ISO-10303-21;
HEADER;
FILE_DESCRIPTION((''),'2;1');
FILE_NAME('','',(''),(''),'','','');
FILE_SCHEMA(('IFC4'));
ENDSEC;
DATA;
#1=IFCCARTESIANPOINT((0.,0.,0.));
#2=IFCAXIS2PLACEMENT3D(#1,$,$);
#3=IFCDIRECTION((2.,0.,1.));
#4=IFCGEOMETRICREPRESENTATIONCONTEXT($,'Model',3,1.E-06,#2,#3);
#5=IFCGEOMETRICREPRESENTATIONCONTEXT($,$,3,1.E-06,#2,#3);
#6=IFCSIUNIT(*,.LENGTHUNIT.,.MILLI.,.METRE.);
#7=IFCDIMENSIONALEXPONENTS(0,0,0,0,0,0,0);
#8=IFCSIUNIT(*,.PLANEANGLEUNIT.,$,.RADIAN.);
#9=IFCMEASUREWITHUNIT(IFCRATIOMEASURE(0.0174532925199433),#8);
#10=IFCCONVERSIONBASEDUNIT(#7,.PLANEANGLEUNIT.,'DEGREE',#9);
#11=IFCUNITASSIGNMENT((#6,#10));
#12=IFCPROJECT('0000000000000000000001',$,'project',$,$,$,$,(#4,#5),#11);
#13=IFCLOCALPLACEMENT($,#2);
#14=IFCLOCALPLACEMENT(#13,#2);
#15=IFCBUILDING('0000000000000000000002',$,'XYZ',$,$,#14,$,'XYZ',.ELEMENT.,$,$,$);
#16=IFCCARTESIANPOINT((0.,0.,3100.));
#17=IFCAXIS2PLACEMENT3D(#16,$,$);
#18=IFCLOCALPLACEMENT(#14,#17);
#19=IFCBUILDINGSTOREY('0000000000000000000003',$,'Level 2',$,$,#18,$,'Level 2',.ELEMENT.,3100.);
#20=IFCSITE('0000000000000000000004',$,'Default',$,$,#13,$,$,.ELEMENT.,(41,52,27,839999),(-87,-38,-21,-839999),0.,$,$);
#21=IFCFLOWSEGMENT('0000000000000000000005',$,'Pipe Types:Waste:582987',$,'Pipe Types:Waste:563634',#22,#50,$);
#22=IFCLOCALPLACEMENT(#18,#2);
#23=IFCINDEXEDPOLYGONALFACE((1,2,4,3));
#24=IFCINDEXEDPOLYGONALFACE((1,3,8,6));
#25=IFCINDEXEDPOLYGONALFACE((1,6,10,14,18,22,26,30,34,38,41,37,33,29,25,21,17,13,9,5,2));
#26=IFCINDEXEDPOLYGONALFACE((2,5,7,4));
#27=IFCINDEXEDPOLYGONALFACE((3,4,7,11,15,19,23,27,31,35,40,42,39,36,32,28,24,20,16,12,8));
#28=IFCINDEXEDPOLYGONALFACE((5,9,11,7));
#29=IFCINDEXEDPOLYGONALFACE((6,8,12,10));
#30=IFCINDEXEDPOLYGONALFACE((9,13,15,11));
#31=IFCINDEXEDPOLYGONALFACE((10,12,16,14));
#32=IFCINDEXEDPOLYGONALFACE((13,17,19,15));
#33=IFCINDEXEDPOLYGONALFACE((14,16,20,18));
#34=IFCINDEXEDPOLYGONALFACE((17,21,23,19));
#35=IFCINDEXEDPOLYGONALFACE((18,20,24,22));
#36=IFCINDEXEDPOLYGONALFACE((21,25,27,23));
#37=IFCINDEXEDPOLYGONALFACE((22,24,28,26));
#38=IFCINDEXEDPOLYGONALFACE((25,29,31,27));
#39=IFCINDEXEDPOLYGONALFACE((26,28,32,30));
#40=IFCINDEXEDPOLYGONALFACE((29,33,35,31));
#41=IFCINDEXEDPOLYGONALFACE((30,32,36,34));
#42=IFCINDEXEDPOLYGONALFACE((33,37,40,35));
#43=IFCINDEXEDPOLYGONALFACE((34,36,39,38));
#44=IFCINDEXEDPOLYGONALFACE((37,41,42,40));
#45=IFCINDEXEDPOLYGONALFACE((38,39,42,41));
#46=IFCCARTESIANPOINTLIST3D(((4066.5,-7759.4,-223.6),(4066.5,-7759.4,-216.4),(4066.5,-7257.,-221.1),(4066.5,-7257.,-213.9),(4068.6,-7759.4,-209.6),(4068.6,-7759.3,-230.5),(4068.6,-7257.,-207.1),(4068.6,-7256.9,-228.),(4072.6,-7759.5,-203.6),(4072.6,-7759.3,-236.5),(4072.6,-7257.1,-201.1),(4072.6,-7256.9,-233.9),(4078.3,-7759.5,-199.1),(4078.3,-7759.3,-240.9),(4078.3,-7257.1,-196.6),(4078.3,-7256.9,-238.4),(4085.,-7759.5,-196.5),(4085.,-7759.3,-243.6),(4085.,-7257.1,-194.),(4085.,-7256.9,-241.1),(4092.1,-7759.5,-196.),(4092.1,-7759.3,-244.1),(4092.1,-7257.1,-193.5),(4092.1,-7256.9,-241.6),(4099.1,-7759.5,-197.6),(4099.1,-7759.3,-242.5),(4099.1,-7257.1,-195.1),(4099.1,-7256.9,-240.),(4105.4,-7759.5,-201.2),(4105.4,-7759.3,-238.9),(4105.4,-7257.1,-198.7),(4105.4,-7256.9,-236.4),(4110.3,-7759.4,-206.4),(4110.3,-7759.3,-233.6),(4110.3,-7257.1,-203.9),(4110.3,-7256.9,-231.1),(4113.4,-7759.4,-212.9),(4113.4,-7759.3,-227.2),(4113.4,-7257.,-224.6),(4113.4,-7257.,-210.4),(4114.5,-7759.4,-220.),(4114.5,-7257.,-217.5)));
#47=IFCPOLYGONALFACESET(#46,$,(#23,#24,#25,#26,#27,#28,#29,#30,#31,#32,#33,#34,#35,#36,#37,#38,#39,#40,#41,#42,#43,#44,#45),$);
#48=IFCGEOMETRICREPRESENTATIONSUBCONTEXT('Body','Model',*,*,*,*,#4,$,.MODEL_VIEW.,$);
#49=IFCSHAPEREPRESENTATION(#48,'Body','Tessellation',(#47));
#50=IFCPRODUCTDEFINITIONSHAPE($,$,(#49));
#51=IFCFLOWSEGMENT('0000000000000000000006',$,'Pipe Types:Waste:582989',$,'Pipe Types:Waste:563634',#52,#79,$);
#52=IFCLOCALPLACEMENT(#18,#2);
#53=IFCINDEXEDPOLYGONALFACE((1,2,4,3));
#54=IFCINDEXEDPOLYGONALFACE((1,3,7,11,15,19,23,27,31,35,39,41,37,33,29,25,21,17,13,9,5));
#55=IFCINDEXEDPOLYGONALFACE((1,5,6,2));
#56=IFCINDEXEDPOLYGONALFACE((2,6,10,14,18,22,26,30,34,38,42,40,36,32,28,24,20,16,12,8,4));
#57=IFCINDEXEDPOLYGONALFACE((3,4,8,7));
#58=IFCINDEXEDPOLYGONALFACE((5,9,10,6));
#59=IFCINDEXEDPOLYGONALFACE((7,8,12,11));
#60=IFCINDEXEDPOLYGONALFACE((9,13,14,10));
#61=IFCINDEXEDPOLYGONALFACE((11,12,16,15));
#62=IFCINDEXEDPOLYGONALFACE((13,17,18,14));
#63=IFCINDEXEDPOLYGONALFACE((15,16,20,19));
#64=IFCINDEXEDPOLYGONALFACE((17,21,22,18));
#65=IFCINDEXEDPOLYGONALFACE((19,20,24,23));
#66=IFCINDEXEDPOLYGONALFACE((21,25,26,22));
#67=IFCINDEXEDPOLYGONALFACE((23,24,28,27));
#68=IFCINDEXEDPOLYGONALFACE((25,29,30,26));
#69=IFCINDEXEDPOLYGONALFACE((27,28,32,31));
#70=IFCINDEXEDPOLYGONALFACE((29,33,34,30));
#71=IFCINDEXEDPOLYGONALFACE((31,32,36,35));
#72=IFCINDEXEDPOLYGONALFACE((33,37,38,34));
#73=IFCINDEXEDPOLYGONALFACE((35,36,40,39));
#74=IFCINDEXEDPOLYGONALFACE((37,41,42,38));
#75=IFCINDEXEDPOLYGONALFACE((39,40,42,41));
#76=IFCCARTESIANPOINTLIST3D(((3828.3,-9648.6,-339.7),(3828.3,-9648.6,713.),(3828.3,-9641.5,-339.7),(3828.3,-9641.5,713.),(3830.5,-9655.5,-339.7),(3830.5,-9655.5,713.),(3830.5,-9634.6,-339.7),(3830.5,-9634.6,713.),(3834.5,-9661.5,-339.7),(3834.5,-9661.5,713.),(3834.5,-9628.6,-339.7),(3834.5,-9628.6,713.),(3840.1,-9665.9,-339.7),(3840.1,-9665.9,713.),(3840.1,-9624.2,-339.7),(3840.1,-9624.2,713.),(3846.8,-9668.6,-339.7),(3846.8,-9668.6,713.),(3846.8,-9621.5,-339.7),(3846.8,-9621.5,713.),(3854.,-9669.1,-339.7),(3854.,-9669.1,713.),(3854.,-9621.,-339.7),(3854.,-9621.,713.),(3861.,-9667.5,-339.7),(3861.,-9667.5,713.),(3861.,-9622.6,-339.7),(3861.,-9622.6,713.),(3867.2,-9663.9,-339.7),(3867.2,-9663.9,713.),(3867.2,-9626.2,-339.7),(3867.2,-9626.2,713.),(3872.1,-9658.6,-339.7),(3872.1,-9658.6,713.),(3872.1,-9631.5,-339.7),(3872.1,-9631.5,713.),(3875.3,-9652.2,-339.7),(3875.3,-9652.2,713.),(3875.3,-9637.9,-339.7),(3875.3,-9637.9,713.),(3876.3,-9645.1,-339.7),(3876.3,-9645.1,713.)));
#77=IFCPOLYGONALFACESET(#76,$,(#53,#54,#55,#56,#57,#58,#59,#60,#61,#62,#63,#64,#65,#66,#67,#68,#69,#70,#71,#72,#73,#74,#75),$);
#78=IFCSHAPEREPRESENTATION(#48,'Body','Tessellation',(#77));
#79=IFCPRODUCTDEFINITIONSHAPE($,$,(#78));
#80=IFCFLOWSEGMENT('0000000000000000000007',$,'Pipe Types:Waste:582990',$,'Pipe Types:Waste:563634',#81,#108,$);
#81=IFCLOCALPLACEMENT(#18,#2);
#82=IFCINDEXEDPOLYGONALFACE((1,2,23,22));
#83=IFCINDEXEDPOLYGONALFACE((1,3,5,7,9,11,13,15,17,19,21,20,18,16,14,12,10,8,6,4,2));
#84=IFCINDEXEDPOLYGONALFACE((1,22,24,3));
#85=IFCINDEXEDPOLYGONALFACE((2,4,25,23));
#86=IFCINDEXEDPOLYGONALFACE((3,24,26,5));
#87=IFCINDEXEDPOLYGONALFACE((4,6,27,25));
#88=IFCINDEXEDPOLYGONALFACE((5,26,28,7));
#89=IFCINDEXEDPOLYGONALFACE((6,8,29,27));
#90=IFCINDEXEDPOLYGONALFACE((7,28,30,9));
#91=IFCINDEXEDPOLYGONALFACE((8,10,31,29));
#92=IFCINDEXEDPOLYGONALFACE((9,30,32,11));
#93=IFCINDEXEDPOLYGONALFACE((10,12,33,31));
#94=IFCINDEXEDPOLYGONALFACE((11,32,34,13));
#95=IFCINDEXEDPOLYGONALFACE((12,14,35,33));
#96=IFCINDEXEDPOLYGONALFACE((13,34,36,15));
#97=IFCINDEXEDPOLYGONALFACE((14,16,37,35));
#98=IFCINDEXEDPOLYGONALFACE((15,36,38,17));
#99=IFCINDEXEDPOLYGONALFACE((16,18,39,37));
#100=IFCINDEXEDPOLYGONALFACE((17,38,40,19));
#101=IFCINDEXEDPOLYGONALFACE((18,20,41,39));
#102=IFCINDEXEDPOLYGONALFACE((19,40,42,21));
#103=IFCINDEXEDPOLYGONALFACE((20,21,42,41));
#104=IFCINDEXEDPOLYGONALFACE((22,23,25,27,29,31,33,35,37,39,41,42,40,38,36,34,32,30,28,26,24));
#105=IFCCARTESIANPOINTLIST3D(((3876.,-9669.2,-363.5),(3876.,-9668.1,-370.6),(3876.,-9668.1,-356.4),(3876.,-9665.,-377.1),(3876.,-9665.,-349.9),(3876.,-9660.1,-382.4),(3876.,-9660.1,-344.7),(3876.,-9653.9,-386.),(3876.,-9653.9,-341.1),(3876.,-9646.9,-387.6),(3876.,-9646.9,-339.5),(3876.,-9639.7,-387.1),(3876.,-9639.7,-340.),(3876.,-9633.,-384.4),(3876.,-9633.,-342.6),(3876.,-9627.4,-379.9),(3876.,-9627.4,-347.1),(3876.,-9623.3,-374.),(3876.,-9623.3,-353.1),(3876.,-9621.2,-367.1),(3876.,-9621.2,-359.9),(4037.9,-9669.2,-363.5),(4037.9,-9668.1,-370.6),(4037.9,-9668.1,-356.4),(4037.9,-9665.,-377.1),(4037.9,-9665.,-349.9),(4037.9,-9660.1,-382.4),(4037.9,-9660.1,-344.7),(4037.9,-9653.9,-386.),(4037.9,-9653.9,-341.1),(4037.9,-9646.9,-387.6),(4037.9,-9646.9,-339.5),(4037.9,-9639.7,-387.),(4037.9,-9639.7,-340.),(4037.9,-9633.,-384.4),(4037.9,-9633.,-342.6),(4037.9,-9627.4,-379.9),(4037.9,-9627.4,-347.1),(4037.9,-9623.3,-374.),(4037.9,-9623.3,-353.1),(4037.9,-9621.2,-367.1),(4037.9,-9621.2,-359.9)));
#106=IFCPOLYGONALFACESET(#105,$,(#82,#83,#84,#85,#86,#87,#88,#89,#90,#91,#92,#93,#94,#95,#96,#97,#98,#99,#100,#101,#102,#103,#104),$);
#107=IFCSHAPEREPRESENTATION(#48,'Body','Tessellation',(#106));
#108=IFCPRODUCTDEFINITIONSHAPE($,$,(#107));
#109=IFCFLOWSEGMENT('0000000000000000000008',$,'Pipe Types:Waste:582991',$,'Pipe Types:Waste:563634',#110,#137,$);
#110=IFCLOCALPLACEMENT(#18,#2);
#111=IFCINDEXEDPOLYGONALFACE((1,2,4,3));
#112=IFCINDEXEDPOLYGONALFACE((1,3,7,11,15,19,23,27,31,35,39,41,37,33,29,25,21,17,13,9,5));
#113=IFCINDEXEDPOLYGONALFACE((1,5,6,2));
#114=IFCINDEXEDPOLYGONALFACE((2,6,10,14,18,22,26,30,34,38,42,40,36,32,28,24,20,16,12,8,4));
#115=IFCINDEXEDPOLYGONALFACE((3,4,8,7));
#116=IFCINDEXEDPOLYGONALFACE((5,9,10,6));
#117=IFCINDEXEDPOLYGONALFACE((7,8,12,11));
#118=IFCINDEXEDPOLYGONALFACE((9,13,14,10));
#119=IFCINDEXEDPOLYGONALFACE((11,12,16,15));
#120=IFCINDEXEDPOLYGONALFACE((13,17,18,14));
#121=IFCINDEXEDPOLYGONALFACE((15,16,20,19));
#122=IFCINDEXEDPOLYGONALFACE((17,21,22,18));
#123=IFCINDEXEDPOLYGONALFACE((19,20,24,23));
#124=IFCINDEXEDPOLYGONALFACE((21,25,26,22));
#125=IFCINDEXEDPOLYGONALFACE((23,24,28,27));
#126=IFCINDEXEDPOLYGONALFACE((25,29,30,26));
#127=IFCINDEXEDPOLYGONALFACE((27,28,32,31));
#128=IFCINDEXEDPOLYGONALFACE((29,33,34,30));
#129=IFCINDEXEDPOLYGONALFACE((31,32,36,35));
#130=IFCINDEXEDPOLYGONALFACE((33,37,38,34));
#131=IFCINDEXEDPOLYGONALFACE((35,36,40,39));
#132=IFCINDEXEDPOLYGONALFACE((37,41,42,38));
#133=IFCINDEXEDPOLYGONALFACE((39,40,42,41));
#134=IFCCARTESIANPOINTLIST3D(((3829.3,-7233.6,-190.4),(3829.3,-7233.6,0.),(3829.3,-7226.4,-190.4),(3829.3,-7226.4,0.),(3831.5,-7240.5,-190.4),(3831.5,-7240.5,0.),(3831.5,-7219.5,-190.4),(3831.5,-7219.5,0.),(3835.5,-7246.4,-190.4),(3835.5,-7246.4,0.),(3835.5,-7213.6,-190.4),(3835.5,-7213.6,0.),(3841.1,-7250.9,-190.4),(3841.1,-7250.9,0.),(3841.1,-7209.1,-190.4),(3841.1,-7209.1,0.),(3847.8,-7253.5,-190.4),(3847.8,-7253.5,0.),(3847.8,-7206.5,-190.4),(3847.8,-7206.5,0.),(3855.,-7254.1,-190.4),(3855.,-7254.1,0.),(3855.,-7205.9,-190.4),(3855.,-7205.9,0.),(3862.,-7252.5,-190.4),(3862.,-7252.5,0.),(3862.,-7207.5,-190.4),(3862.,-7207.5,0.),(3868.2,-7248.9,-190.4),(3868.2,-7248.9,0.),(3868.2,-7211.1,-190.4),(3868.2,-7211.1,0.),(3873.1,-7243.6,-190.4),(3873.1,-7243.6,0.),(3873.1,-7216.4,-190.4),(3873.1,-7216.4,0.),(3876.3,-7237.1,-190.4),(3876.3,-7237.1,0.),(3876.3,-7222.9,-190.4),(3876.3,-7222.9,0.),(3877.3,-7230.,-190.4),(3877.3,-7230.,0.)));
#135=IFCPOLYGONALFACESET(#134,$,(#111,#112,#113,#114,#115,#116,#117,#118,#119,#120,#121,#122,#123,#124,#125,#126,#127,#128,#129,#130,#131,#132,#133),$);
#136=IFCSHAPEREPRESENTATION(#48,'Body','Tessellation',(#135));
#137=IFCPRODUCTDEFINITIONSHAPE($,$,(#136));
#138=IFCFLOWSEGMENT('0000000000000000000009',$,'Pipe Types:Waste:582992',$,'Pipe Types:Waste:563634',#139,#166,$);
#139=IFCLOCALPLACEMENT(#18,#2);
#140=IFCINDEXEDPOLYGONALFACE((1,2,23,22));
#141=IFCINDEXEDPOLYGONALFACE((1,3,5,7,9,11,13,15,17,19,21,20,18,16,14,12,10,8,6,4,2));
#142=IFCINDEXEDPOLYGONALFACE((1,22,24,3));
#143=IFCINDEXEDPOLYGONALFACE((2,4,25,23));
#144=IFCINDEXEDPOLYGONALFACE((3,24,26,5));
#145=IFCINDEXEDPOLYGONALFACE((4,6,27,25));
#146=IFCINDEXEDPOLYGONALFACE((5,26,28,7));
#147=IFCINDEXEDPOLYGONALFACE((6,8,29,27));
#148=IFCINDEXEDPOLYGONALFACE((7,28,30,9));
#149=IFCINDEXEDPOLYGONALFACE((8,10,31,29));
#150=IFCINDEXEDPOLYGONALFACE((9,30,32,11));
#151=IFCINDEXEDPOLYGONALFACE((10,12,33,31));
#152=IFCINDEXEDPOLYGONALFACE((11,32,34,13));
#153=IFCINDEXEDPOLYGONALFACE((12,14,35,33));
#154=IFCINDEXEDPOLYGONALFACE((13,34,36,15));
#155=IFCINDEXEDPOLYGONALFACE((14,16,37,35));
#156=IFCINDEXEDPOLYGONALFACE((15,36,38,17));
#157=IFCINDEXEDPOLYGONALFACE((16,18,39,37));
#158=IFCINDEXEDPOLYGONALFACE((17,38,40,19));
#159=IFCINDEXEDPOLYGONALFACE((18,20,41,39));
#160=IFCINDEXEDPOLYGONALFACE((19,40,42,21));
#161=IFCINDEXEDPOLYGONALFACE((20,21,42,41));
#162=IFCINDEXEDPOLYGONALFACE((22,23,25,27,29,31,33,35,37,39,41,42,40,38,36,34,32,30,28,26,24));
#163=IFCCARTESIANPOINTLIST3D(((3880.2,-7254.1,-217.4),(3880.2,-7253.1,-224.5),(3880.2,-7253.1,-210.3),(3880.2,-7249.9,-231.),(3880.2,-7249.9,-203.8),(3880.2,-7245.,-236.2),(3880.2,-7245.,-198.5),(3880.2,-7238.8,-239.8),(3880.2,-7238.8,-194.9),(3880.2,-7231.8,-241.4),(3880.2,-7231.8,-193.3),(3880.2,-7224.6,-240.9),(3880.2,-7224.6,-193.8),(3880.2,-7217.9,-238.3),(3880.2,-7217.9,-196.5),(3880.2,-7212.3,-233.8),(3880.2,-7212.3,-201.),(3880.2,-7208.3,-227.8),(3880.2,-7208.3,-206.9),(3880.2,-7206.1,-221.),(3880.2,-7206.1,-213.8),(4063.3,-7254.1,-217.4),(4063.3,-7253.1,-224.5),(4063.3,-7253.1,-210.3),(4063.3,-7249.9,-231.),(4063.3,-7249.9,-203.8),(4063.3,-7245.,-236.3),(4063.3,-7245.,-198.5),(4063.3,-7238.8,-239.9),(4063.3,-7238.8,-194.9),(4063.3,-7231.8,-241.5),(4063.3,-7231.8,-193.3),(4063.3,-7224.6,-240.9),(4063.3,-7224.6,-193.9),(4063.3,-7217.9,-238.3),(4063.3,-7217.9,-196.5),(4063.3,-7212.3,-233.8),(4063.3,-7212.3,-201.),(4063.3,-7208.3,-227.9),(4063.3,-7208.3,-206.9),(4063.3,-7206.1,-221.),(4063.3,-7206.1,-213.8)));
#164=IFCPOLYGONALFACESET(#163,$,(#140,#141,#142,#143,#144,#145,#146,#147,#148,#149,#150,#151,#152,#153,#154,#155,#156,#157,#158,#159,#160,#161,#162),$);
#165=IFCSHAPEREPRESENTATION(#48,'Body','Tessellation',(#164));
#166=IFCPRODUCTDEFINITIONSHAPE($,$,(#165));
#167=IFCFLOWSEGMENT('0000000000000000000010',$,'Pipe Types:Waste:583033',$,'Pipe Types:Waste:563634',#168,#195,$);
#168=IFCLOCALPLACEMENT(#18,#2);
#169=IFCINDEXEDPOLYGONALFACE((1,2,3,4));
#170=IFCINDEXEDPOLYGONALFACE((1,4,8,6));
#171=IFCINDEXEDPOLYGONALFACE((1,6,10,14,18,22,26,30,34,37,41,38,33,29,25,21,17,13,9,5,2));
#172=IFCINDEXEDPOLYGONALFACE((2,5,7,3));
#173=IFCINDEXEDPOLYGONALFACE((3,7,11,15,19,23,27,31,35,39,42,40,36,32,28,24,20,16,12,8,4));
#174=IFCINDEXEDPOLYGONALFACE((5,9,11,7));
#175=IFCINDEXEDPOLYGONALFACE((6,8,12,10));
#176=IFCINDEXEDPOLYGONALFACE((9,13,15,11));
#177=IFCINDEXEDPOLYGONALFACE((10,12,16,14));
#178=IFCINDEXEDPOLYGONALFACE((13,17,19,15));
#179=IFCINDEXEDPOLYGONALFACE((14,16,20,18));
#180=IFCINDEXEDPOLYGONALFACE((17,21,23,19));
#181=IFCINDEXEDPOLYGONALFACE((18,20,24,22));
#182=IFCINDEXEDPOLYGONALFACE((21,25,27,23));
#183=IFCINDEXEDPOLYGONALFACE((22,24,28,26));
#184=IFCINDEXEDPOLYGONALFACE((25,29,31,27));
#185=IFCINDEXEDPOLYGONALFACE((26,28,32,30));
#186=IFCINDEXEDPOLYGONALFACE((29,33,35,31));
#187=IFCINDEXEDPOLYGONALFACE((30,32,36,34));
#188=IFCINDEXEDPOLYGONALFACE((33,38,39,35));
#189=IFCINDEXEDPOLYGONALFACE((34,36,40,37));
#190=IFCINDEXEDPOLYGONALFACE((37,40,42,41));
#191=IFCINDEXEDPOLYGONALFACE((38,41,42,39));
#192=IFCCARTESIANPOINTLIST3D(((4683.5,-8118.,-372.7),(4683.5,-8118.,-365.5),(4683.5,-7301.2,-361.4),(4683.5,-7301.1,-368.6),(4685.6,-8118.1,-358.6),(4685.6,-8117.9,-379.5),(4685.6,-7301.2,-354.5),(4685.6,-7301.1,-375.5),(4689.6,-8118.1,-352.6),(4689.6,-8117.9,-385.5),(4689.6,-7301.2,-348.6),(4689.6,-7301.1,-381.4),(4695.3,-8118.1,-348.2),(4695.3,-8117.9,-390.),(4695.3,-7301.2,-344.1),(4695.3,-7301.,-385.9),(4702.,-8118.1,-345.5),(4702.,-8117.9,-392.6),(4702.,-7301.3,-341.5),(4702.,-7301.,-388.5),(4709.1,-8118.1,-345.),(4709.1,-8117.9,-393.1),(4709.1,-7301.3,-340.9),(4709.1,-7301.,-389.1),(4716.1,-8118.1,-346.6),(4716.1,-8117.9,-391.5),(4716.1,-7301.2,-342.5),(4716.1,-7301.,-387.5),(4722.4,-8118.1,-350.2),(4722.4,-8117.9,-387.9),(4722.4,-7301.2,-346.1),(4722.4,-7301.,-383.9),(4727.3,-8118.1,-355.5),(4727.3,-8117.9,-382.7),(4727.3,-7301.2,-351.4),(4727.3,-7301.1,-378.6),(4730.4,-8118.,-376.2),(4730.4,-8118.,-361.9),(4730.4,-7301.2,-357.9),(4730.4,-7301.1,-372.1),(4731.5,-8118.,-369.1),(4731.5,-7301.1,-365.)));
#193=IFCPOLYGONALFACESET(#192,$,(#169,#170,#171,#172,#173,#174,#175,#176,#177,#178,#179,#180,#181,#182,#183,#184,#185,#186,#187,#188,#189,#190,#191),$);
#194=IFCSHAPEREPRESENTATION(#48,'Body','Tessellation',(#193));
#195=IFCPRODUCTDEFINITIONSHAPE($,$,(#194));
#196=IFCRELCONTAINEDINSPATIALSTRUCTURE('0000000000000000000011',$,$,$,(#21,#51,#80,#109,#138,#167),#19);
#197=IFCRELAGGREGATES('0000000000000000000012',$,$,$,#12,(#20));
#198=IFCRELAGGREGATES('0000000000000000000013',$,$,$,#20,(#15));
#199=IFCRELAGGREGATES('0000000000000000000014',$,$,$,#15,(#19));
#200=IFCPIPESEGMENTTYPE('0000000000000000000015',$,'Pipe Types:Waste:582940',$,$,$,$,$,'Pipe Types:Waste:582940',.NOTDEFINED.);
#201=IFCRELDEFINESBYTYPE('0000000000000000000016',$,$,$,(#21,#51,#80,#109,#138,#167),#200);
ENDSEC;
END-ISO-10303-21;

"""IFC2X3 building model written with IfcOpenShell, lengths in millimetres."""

from ifc_helpers import new_model, entity, si_unit, converted_unit, direction, frame, frame_2d, origin, origin_2d_with_axis, place, context, subcontext, project, spatial, circle, extrude, type_object, element, save


model = new_model("IFC2X3")

# Units and contexts
model_context = context("Model", 3, precision=1e-06, world=origin(), true_north=direction((2.0, 0.0, 1.0)))
context_of_model = context(None, 3, precision=1e-06, world=origin(), true_north=direction((2.0, 0.0, 1.0)))
body_context = subcontext(model_context, "Body", "Model", "MODEL_VIEW")
ifc_project = project(units=[si_unit("LENGTHUNIT", "METRE", prefix="MILLI"), converted_unit("PLANEANGLEUNIT", "DEGREE", entity("IfcRatioMeasure", 0.0174532925199433), si_unit("PLANEANGLEUNIT", "RADIAN"), dimensions=[0, 0, 0, 0, 0, 0, 0])], contexts=[model_context, context_of_model])

# Site, building, storey
site_placement = place(None, origin())
site = spatial("IfcSite", under=ifc_project, at=site_placement, Name="Default", CompositionType="ELEMENT", RefLatitude=(41, 52, 27, 839999), RefLongitude=(-87, -38, -21, -839999), RefElevation=0.0)
building_placement = place(site_placement, origin())
building = spatial("IfcBuilding", under=site, at=building_placement, Name="XYZ", LongName="XYZ", CompositionType="ELEMENT")
storey_placement = place(building_placement, frame((0.0, 0.0, 3100.0)))
storey = spatial("IfcBuildingStorey", under=building, at=storey_placement, Name="Level 2", LongName="Level 2", CompositionType="ELEMENT", Elevation=3100.0)

# Flow segments
pipe_segment_type_1 = type_object("IfcPipeSegmentType", Name="Pipe Types:Waste:582940", ElementType="Pipe Types:Waste:582940", PredefinedType="NOTDEFINED")
flow_segment_1_placement = place(storey_placement, origin())
element("IfcFlowSegment", 1, at=flow_segment_1_placement, inside=storey, type_object=pipe_segment_type_1, Name="Pipe Types:Waste:582987", ObjectType="Pipe Types:Waste:563634", context=body_context, shape_type="SweptSolid", body=[
    extrude(circle(Radius=24.1, at=frame_2d((0.0, 0.0), x_axis=(1.0, 0.0))), frame((4090.3, -7759.4, -220.0), z_axis=(0.0, 0.999988, 0.005), x_axis=(1.0, 0.0, 0.0)), (0.0, 0.0, 1.0), 502.4),
])
flow_segment_2_placement = place(storey_placement, origin())
element("IfcFlowSegment", 2, at=flow_segment_2_placement, inside=storey, type_object=pipe_segment_type_1, Name="Pipe Types:Waste:582989", ObjectType="Pipe Types:Waste:563634", context=body_context, shape_type="SweptSolid", body=[
    extrude(circle(Radius=24.1, at=origin_2d_with_axis()), frame((3852.2, -9645.1, -339.7)), (0.0, 0.0, 1.0), 1052.7),
])
flow_segment_3_placement = place(storey_placement, origin())
element("IfcFlowSegment", 3, at=flow_segment_3_placement, inside=storey, type_object=pipe_segment_type_1, Name="Pipe Types:Waste:582990", ObjectType="Pipe Types:Waste:563634", context=body_context, shape_type="SweptSolid", body=[
    extrude(circle(Radius=24.1, at=origin_2d_with_axis()), frame((3876.0, -9645.1, -363.5), z_axis=(1.0, 0.0, 0.00006), x_axis=(0.0, -1.0, 0.0)), (0.0, 0.0, 1.0), 161.9),
])
flow_segment_4_placement = place(storey_placement, origin())
element("IfcFlowSegment", 4, at=flow_segment_4_placement, inside=storey, type_object=pipe_segment_type_1, Name="Pipe Types:Waste:582991", ObjectType="Pipe Types:Waste:563634", context=body_context, shape_type="SweptSolid", body=[
    extrude(circle(Radius=24.1, at=origin_2d_with_axis()), frame((3853.2, -7230.0, -190.4)), (0.0, 0.0, 1.0), 190.4),
])
flow_segment_5_placement = place(storey_placement, origin())
element("IfcFlowSegment", 5, at=flow_segment_5_placement, inside=storey, type_object=pipe_segment_type_1, Name="Pipe Types:Waste:582992", ObjectType="Pipe Types:Waste:563634", context=body_context, shape_type="SweptSolid", body=[
    extrude(circle(Radius=24.1, at=frame_2d((0.0, 0.0), x_axis=(1.0, 0.0))), frame((3880.2, -7230.0, -217.4), z_axis=(1.0, 0.000001, -0.000125), x_axis=(0.000001, -1.0, 0.0)), (0.0, 0.0, 1.0), 183.2),
])
flow_segment_6_placement = place(storey_placement, origin())
element("IfcFlowSegment", 6, at=flow_segment_6_placement, inside=storey, type_object=pipe_segment_type_1, Name="Pipe Types:Waste:583033", ObjectType="Pipe Types:Waste:563634", context=body_context, shape_type="SweptSolid", body=[
    extrude(circle(Radius=24.1, at=origin_2d_with_axis()), frame((4707.3, -8118.0, -369.1), z_axis=(0.0, 0.999988, 0.004979), x_axis=(1.0, 0.0, 0.0)), (0.0, 0.0, 1.0), 816.9),
])

save(model, "model.ifc")
